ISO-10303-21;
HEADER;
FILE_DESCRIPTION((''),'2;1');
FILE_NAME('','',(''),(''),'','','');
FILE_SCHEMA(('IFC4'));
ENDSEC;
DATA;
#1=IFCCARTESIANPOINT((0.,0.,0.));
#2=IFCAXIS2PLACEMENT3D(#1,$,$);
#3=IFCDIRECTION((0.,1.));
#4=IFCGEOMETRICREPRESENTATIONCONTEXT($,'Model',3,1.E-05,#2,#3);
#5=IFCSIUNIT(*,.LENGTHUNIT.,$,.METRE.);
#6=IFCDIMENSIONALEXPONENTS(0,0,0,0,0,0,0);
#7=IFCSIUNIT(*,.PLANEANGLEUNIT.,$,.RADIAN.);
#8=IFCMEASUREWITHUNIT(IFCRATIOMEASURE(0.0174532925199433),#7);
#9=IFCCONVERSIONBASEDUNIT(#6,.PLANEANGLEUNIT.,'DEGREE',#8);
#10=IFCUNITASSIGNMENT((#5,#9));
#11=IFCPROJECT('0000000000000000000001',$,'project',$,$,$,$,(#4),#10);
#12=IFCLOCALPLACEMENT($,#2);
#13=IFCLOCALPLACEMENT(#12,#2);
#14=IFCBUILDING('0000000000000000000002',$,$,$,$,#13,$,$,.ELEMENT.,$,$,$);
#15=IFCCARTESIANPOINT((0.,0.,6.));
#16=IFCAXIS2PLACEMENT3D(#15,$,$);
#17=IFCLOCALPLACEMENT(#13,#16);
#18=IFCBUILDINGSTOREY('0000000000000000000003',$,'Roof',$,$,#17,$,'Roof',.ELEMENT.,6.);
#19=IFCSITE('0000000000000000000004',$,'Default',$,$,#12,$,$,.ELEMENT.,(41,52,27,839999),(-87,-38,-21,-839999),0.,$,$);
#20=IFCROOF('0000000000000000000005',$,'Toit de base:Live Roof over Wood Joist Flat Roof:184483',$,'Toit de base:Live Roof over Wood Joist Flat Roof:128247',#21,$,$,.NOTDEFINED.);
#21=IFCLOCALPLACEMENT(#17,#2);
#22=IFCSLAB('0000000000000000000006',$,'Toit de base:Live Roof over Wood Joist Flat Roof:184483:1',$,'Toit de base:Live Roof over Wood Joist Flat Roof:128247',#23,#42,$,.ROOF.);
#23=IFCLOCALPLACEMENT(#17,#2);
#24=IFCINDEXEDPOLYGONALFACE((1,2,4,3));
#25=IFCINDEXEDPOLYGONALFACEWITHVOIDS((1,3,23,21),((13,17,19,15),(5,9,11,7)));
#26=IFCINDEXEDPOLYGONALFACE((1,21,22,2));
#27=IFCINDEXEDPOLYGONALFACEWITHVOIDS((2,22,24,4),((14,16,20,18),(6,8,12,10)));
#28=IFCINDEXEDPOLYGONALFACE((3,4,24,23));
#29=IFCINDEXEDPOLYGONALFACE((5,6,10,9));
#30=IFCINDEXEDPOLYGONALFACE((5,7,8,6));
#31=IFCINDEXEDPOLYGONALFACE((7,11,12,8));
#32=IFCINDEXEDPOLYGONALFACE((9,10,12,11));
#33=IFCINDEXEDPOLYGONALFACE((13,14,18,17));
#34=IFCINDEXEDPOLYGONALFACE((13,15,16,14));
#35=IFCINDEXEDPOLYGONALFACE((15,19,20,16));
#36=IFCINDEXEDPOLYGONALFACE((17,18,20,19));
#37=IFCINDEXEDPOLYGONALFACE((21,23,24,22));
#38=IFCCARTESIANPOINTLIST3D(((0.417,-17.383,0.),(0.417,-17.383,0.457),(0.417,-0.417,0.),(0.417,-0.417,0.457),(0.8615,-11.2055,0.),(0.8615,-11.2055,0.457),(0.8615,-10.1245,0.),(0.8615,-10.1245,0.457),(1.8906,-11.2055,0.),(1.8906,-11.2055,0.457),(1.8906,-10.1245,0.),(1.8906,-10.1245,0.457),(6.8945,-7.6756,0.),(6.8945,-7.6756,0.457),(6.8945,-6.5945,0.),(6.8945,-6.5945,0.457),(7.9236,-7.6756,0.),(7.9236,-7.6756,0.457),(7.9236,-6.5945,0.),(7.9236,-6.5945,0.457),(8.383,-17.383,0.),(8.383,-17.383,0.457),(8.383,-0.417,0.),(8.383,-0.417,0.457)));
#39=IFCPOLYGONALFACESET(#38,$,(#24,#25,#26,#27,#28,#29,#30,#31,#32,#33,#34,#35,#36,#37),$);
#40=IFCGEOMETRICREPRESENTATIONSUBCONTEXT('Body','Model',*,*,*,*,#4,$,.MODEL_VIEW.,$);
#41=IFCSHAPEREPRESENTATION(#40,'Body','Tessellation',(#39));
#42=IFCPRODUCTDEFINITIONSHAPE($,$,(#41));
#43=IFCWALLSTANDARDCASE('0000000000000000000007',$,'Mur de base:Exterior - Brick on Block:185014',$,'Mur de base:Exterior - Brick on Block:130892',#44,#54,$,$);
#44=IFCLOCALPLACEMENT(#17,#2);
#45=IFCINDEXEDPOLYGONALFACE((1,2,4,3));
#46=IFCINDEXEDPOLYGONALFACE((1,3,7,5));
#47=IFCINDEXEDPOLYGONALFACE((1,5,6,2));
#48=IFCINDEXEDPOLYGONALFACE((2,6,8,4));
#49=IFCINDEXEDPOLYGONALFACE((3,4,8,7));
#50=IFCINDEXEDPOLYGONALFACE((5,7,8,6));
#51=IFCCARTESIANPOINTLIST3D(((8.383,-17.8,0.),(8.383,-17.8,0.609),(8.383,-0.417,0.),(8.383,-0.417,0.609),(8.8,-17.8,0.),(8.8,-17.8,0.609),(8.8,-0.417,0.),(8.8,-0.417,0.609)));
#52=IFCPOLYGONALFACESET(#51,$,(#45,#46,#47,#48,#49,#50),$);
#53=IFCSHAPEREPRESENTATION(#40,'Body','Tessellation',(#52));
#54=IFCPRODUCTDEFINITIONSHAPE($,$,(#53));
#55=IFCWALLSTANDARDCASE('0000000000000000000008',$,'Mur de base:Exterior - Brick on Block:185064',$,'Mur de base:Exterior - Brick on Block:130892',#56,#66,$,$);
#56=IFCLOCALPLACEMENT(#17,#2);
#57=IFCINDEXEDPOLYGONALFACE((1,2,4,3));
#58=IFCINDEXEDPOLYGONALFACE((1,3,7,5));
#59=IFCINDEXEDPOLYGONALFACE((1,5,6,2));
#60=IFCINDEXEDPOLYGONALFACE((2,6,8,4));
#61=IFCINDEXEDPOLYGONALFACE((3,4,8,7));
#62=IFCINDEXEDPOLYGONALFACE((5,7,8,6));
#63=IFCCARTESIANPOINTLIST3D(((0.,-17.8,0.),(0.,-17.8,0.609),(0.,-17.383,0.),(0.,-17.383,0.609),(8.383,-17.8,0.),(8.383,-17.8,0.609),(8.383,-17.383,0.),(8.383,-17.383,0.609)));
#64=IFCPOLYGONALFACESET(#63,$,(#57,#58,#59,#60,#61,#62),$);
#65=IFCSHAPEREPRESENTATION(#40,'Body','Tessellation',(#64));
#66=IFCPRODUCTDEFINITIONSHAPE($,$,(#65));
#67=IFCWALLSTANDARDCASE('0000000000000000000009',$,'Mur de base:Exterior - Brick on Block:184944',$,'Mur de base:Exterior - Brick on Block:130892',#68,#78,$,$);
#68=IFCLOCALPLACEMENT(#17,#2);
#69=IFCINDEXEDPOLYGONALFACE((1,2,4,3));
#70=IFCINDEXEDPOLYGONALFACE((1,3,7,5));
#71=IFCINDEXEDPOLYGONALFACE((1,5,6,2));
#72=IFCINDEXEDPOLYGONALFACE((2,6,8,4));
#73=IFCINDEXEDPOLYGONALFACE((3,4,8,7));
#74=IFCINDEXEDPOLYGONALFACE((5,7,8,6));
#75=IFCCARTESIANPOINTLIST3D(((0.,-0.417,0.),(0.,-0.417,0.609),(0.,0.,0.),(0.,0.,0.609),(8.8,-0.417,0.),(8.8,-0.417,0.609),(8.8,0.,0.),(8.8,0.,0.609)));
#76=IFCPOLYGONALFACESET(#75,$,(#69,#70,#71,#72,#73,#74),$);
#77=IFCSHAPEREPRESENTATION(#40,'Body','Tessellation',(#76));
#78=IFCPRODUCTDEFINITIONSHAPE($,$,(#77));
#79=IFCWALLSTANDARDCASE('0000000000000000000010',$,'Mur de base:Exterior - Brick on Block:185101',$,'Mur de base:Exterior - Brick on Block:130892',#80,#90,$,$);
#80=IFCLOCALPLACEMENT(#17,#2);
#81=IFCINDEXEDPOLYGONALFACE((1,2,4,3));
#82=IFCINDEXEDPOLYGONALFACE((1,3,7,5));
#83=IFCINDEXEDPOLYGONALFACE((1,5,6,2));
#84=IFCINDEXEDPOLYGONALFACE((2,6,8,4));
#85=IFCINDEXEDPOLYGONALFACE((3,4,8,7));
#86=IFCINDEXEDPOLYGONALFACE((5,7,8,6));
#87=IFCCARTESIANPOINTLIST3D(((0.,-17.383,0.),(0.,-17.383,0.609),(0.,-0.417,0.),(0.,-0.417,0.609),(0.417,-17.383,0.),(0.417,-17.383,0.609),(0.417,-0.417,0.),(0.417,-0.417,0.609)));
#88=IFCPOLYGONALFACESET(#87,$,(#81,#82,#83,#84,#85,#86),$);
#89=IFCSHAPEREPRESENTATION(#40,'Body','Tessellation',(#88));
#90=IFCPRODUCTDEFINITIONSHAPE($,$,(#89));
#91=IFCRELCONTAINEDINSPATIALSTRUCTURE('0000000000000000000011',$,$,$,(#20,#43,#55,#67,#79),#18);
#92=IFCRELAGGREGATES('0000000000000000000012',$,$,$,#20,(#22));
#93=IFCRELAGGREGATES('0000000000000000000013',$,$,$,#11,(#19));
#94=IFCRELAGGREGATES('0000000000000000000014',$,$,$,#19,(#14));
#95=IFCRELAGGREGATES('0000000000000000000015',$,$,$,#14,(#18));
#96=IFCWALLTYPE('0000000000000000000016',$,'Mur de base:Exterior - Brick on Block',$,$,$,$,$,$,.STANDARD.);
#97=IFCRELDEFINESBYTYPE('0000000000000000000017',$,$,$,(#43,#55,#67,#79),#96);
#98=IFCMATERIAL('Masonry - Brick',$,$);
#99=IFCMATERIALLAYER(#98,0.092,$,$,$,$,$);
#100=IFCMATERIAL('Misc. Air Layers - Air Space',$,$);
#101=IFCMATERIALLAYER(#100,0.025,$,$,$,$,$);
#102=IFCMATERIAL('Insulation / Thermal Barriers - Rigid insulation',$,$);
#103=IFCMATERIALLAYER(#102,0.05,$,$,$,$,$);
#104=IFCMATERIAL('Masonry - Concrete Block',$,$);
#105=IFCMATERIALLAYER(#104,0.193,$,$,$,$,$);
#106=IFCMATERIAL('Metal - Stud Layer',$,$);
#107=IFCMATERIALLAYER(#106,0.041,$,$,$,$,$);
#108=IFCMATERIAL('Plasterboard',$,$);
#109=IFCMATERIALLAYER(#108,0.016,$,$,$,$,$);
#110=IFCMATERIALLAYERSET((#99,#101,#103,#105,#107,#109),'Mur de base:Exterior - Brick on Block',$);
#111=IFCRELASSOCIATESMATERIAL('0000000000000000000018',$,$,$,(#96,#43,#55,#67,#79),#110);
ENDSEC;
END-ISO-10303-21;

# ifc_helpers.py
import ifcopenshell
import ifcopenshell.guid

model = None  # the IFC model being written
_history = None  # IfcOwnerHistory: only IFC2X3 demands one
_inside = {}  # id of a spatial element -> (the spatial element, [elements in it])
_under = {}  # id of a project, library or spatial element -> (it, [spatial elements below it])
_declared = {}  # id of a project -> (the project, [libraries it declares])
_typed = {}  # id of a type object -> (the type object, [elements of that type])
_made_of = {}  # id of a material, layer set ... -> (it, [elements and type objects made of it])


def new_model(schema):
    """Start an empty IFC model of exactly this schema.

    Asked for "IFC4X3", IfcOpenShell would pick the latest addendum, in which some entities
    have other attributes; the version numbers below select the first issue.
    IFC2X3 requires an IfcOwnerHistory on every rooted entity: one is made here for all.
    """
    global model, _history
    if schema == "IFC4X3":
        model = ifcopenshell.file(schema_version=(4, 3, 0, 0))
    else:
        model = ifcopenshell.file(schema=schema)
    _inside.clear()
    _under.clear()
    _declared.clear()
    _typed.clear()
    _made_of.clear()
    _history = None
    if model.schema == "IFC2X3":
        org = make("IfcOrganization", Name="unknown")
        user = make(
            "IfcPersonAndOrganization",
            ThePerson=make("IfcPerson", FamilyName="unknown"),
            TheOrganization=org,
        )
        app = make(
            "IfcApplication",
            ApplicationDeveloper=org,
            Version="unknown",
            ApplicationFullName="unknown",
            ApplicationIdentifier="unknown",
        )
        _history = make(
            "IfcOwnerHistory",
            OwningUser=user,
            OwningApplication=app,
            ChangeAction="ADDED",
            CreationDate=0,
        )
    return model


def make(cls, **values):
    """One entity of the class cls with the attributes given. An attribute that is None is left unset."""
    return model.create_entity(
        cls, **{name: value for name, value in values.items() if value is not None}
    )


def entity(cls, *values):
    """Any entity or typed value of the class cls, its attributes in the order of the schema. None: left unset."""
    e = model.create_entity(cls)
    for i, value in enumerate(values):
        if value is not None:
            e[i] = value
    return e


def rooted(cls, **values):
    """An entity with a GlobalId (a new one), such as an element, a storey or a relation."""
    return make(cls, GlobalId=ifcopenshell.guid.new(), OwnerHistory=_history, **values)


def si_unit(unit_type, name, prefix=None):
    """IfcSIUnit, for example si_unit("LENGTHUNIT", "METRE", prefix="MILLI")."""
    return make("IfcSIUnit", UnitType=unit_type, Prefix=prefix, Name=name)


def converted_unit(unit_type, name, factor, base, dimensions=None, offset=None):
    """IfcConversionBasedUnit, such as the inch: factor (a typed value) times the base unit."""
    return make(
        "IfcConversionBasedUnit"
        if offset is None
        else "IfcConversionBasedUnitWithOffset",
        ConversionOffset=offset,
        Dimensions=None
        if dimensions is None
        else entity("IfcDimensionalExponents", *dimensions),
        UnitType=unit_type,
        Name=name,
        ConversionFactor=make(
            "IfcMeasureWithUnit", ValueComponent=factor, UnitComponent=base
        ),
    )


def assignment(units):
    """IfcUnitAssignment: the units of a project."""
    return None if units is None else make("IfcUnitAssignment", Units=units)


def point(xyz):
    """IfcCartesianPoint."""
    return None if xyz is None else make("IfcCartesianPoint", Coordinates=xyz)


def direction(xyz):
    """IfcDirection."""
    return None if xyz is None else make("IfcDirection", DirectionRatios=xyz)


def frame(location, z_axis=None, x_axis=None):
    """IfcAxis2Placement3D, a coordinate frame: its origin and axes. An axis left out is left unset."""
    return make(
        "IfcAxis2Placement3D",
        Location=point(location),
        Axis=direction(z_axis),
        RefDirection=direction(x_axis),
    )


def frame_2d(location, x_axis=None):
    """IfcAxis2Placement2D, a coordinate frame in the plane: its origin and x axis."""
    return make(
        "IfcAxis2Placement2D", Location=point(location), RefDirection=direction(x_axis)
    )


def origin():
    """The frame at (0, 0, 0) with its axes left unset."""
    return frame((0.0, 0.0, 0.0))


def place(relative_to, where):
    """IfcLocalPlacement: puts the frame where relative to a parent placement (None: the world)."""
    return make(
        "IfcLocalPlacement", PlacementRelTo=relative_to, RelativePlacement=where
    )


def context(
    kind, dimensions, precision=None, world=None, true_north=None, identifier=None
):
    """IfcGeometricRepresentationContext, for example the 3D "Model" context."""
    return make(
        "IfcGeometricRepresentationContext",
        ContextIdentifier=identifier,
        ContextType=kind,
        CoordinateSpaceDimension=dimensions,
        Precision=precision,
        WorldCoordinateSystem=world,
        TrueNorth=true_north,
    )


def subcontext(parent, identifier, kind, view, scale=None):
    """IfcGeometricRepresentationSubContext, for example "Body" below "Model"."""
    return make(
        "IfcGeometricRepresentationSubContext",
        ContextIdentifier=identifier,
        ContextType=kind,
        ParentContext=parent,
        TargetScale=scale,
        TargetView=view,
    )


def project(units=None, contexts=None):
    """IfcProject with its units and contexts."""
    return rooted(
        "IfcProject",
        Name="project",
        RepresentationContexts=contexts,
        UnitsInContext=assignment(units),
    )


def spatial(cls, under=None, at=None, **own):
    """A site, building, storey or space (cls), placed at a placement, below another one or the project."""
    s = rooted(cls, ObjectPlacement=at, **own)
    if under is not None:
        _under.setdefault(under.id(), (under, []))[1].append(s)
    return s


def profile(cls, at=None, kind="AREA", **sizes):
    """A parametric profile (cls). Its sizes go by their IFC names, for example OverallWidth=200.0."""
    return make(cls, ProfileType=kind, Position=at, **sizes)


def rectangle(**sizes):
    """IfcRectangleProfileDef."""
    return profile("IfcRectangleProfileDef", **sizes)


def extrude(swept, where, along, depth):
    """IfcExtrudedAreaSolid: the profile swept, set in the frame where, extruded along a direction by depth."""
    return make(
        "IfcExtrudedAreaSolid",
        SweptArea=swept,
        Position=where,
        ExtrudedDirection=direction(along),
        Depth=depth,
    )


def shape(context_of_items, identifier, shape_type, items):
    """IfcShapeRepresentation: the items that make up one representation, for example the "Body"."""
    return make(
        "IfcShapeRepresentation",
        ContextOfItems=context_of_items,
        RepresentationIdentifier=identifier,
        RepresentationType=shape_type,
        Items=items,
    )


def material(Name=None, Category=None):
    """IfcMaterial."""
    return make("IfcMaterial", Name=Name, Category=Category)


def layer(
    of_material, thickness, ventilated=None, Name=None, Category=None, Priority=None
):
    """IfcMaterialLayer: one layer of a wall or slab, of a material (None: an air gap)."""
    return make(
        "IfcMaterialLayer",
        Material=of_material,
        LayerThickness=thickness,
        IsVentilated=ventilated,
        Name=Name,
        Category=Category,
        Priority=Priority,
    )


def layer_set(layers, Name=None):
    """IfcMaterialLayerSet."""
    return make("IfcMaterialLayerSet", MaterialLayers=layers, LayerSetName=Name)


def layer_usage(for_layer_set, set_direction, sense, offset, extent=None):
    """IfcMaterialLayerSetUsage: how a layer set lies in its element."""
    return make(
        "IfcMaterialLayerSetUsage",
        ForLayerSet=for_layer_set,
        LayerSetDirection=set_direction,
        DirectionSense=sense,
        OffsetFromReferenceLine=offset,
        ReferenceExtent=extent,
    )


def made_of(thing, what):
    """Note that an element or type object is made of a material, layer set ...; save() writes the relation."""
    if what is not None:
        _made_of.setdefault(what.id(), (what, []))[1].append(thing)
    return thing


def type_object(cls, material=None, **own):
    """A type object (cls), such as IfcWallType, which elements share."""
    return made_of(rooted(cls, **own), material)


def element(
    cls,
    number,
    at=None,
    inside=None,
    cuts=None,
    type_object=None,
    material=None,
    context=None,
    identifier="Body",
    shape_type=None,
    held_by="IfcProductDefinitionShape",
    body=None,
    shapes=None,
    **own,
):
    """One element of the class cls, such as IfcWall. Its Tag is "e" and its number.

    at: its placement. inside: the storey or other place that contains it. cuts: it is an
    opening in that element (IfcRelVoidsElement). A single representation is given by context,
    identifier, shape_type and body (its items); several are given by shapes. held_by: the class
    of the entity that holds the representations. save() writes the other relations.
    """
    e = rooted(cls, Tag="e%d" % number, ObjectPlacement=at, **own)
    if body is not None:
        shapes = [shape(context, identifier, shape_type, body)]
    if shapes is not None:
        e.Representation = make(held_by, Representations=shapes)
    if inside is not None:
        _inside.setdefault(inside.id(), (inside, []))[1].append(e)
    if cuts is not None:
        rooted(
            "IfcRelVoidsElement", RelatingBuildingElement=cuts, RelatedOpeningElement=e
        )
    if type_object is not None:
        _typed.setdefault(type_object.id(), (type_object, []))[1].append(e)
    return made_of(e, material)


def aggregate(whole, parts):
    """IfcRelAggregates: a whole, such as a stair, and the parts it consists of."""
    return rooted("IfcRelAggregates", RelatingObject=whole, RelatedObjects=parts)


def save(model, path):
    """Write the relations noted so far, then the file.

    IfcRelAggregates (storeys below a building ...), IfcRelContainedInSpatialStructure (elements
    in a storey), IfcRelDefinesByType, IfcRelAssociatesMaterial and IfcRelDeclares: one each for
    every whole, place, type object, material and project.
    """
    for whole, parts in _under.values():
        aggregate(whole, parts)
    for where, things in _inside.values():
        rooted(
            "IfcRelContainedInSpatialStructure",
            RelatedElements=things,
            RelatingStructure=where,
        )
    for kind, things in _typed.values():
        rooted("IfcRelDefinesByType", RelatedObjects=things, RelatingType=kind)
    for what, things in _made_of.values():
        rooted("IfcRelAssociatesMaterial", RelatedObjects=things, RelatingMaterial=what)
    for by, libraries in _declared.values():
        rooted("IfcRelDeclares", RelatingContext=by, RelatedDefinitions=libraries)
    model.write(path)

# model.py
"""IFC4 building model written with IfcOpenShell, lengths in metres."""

from ifc_helpers import new_model, entity, si_unit, converted_unit, direction, frame, frame_2d, origin, place, context, subcontext, project, spatial, rectangle, extrude, material, layer, layer_set, layer_usage, type_object, element, aggregate, save


model = new_model("IFC4")

# Units and contexts
model_context = context("Model", 3, precision=1e-05, world=origin(), true_north=direction((0.0, 1.0)))
body_context = subcontext(model_context, "Body", "Model", "MODEL_VIEW")
ifc_project = project(units=[si_unit("LENGTHUNIT", "METRE"), converted_unit("PLANEANGLEUNIT", "DEGREE", entity("IfcRatioMeasure", 0.0174532925199433), si_unit("PLANEANGLEUNIT", "RADIAN"), dimensions=[0, 0, 0, 0, 0, 0, 0])], contexts=[model_context])

# Site, building, storey
site_placement = place(None, origin())
site = spatial("IfcSite", under=ifc_project, at=site_placement, Name="Default", CompositionType="ELEMENT", RefLatitude=(41, 52, 27, 839999), RefLongitude=(-87, -38, -21, -839999), RefElevation=0.0)
building_placement = place(site_placement, origin())
building = spatial("IfcBuilding", under=site, at=building_placement, CompositionType="ELEMENT")
storey_placement = place(building_placement, frame((0.0, 0.0, 6.0)))
storey = spatial("IfcBuildingStorey", under=building, at=storey_placement, Name="Roof", LongName="Roof", CompositionType="ELEMENT", Elevation=6.0)

# Roof, slab, openings
roof_placement = place(storey_placement, origin())
roof = element("IfcRoof", 1, at=roof_placement, inside=storey, Name="Toit de base:Live Roof over Wood Joist Flat Roof:184483", ObjectType="Toit de base:Live Roof over Wood Joist Flat Roof:128247", PredefinedType="NOTDEFINED")
slab_placement = place(storey_placement, origin())
slab = element("IfcSlab", 2, at=slab_placement, Name="Toit de base:Live Roof over Wood Joist Flat Roof:184483:1", ObjectType="Toit de base:Live Roof over Wood Joist Flat Roof:128247", PredefinedType="ROOF", context=body_context, shape_type="SweptSolid", body=[
    extrude(rectangle(XDim=16.966, YDim=7.966, at=frame_2d((0.0, 0.0), x_axis=(1.0, 0.0))), frame((4.4, -8.9, 0.0), z_axis=(0.0, 0.0, 1.0), x_axis=(0.0, -1.0, 0.0)), (0.0, 0.0, 1.0), 0.457),
])
opening_1_placement = place(storey_placement, origin())
element("IfcOpeningElement", 3, at=opening_1_placement, cuts=slab, ObjectType="Opening", context=body_context, shape_type="SweptSolid", body=[
    extrude(rectangle(XDim=1.0291, YDim=1.0811, at=frame_2d((0.0, 0.0), x_axis=(1.0, 0.0))), frame((7.409, -7.135, 0.0), z_axis=(0.0, 0.0, 1.0), x_axis=(-1.0, 0.0, 0.0)), (0.0, 0.0, 1.0), 0.457),
])
opening_2_placement = place(storey_placement, origin())
element("IfcOpeningElement", 4, at=opening_2_placement, cuts=slab, ObjectType="Opening", context=body_context, shape_type="SweptSolid", body=[
    extrude(rectangle(XDim=1.0291, YDim=1.0811, at=frame_2d((0.0, 0.0), x_axis=(1.0, 0.0))), frame((1.376, -10.665, 0.0), z_axis=(0.0, 0.0, 1.0), x_axis=(-1.0, 0.0, 0.0)), (0.0, 0.0, 1.0), 0.457),
])
aggregate(roof, [slab])

# Walls
ifc_material_1 = material(Name="Masonry - Brick")
ifc_layer_1 = layer(ifc_material_1, 0.092)
ifc_material_2 = material(Name="Misc. Air Layers - Air Space")
ifc_layer_2 = layer(ifc_material_2, 0.025)
ifc_material_3 = material(Name="Insulation / Thermal Barriers - Rigid insulation")
ifc_layer_3 = layer(ifc_material_3, 0.05)
ifc_material_4 = material(Name="Masonry - Concrete Block")
ifc_layer_4 = layer(ifc_material_4, 0.193)
ifc_material_5 = material(Name="Metal - Stud Layer")
ifc_layer_5 = layer(ifc_material_5, 0.041)
ifc_material_6 = material(Name="Plasterboard")
ifc_layer_6 = layer(ifc_material_6, 0.016)
ifc_layer_set = layer_set([ifc_layer_1, ifc_layer_2, ifc_layer_3, ifc_layer_4, ifc_layer_5, ifc_layer_6], Name="Mur de base:Exterior - Brick on Block")
ifc_layer_usage_1 = layer_usage(ifc_layer_set, "AXIS2", "NEGATIVE", 0.2085)
wall_type = type_object("IfcWallType", Name="Mur de base:Exterior - Brick on Block", PredefinedType="STANDARD", material=ifc_layer_set)
wall_1_placement = place(storey_placement, frame((8.5915, -0.417, 0.0), z_axis=(0.0, 0.0, 1.0), x_axis=(0.0, -1.0, 0.0)))
element("IfcWallStandardCase", 5, at=wall_1_placement, inside=storey, type_object=wall_type, material=ifc_layer_usage_1, Name="Mur de base:Exterior - Brick on Block:185014", ObjectType="Mur de base:Exterior - Brick on Block:130892", context=body_context, shape_type="SweptSolid", body=[
    extrude(rectangle(XDim=17.383, YDim=0.417, at=frame_2d((8.6915, 0.0), x_axis=(-1.0, 0.0))), origin(), (0.0, 0.0, 1.0), 0.609),
])
ifc_layer_usage_2 = layer_usage(ifc_layer_set, "AXIS2", "NEGATIVE", 0.2085)
wall_2_placement = place(storey_placement, frame((8.383, -17.5915, 0.0), z_axis=(0.0, 0.0, 1.0), x_axis=(-1.0, 0.0, 0.0)))
element("IfcWallStandardCase", 6, at=wall_2_placement, inside=storey, type_object=wall_type, material=ifc_layer_usage_2, Name="Mur de base:Exterior - Brick on Block:185064", ObjectType="Mur de base:Exterior - Brick on Block:130892", context=body_context, shape_type="SweptSolid", body=[
    extrude(rectangle(XDim=8.383, YDim=0.417, at=frame_2d((4.1915, 0.0), x_axis=(-1.0, 0.0))), origin(), (0.0, 0.0, 1.0), 0.609),
])
ifc_layer_usage_3 = layer_usage(ifc_layer_set, "AXIS2", "NEGATIVE", 0.2085)
wall_3_placement = place(storey_placement, frame((0.0, -0.2085, 0.0)))
element("IfcWallStandardCase", 7, at=wall_3_placement, inside=storey, type_object=wall_type, material=ifc_layer_usage_3, Name="Mur de base:Exterior - Brick on Block:184944", ObjectType="Mur de base:Exterior - Brick on Block:130892", context=body_context, shape_type="SweptSolid", body=[
    extrude(rectangle(XDim=8.8, YDim=0.417, at=frame_2d((4.4, 0.0), x_axis=(-1.0, 0.0))), origin(), (0.0, 0.0, 1.0), 0.609),
])
ifc_layer_usage_4 = layer_usage(ifc_layer_set, "AXIS2", "NEGATIVE", 0.2085)
wall_4_placement = place(storey_placement, frame((0.2085, -17.383, 0.0), z_axis=(0.0, 0.0, 1.0), x_axis=(0.0, 1.0, 0.0)))
element("IfcWallStandardCase", 8, at=wall_4_placement, inside=storey, type_object=wall_type, material=ifc_layer_usage_4, Name="Mur de base:Exterior - Brick on Block:185101", ObjectType="Mur de base:Exterior - Brick on Block:130892", context=body_context, shape_type="SweptSolid", body=[
    extrude(rectangle(XDim=16.966, YDim=0.417, at=frame_2d((8.483, 0.0), x_axis=(-1.0, 0.0))), origin(), (0.0, 0.0, 1.0), 0.609),
])

save(model, "model.ifc")
